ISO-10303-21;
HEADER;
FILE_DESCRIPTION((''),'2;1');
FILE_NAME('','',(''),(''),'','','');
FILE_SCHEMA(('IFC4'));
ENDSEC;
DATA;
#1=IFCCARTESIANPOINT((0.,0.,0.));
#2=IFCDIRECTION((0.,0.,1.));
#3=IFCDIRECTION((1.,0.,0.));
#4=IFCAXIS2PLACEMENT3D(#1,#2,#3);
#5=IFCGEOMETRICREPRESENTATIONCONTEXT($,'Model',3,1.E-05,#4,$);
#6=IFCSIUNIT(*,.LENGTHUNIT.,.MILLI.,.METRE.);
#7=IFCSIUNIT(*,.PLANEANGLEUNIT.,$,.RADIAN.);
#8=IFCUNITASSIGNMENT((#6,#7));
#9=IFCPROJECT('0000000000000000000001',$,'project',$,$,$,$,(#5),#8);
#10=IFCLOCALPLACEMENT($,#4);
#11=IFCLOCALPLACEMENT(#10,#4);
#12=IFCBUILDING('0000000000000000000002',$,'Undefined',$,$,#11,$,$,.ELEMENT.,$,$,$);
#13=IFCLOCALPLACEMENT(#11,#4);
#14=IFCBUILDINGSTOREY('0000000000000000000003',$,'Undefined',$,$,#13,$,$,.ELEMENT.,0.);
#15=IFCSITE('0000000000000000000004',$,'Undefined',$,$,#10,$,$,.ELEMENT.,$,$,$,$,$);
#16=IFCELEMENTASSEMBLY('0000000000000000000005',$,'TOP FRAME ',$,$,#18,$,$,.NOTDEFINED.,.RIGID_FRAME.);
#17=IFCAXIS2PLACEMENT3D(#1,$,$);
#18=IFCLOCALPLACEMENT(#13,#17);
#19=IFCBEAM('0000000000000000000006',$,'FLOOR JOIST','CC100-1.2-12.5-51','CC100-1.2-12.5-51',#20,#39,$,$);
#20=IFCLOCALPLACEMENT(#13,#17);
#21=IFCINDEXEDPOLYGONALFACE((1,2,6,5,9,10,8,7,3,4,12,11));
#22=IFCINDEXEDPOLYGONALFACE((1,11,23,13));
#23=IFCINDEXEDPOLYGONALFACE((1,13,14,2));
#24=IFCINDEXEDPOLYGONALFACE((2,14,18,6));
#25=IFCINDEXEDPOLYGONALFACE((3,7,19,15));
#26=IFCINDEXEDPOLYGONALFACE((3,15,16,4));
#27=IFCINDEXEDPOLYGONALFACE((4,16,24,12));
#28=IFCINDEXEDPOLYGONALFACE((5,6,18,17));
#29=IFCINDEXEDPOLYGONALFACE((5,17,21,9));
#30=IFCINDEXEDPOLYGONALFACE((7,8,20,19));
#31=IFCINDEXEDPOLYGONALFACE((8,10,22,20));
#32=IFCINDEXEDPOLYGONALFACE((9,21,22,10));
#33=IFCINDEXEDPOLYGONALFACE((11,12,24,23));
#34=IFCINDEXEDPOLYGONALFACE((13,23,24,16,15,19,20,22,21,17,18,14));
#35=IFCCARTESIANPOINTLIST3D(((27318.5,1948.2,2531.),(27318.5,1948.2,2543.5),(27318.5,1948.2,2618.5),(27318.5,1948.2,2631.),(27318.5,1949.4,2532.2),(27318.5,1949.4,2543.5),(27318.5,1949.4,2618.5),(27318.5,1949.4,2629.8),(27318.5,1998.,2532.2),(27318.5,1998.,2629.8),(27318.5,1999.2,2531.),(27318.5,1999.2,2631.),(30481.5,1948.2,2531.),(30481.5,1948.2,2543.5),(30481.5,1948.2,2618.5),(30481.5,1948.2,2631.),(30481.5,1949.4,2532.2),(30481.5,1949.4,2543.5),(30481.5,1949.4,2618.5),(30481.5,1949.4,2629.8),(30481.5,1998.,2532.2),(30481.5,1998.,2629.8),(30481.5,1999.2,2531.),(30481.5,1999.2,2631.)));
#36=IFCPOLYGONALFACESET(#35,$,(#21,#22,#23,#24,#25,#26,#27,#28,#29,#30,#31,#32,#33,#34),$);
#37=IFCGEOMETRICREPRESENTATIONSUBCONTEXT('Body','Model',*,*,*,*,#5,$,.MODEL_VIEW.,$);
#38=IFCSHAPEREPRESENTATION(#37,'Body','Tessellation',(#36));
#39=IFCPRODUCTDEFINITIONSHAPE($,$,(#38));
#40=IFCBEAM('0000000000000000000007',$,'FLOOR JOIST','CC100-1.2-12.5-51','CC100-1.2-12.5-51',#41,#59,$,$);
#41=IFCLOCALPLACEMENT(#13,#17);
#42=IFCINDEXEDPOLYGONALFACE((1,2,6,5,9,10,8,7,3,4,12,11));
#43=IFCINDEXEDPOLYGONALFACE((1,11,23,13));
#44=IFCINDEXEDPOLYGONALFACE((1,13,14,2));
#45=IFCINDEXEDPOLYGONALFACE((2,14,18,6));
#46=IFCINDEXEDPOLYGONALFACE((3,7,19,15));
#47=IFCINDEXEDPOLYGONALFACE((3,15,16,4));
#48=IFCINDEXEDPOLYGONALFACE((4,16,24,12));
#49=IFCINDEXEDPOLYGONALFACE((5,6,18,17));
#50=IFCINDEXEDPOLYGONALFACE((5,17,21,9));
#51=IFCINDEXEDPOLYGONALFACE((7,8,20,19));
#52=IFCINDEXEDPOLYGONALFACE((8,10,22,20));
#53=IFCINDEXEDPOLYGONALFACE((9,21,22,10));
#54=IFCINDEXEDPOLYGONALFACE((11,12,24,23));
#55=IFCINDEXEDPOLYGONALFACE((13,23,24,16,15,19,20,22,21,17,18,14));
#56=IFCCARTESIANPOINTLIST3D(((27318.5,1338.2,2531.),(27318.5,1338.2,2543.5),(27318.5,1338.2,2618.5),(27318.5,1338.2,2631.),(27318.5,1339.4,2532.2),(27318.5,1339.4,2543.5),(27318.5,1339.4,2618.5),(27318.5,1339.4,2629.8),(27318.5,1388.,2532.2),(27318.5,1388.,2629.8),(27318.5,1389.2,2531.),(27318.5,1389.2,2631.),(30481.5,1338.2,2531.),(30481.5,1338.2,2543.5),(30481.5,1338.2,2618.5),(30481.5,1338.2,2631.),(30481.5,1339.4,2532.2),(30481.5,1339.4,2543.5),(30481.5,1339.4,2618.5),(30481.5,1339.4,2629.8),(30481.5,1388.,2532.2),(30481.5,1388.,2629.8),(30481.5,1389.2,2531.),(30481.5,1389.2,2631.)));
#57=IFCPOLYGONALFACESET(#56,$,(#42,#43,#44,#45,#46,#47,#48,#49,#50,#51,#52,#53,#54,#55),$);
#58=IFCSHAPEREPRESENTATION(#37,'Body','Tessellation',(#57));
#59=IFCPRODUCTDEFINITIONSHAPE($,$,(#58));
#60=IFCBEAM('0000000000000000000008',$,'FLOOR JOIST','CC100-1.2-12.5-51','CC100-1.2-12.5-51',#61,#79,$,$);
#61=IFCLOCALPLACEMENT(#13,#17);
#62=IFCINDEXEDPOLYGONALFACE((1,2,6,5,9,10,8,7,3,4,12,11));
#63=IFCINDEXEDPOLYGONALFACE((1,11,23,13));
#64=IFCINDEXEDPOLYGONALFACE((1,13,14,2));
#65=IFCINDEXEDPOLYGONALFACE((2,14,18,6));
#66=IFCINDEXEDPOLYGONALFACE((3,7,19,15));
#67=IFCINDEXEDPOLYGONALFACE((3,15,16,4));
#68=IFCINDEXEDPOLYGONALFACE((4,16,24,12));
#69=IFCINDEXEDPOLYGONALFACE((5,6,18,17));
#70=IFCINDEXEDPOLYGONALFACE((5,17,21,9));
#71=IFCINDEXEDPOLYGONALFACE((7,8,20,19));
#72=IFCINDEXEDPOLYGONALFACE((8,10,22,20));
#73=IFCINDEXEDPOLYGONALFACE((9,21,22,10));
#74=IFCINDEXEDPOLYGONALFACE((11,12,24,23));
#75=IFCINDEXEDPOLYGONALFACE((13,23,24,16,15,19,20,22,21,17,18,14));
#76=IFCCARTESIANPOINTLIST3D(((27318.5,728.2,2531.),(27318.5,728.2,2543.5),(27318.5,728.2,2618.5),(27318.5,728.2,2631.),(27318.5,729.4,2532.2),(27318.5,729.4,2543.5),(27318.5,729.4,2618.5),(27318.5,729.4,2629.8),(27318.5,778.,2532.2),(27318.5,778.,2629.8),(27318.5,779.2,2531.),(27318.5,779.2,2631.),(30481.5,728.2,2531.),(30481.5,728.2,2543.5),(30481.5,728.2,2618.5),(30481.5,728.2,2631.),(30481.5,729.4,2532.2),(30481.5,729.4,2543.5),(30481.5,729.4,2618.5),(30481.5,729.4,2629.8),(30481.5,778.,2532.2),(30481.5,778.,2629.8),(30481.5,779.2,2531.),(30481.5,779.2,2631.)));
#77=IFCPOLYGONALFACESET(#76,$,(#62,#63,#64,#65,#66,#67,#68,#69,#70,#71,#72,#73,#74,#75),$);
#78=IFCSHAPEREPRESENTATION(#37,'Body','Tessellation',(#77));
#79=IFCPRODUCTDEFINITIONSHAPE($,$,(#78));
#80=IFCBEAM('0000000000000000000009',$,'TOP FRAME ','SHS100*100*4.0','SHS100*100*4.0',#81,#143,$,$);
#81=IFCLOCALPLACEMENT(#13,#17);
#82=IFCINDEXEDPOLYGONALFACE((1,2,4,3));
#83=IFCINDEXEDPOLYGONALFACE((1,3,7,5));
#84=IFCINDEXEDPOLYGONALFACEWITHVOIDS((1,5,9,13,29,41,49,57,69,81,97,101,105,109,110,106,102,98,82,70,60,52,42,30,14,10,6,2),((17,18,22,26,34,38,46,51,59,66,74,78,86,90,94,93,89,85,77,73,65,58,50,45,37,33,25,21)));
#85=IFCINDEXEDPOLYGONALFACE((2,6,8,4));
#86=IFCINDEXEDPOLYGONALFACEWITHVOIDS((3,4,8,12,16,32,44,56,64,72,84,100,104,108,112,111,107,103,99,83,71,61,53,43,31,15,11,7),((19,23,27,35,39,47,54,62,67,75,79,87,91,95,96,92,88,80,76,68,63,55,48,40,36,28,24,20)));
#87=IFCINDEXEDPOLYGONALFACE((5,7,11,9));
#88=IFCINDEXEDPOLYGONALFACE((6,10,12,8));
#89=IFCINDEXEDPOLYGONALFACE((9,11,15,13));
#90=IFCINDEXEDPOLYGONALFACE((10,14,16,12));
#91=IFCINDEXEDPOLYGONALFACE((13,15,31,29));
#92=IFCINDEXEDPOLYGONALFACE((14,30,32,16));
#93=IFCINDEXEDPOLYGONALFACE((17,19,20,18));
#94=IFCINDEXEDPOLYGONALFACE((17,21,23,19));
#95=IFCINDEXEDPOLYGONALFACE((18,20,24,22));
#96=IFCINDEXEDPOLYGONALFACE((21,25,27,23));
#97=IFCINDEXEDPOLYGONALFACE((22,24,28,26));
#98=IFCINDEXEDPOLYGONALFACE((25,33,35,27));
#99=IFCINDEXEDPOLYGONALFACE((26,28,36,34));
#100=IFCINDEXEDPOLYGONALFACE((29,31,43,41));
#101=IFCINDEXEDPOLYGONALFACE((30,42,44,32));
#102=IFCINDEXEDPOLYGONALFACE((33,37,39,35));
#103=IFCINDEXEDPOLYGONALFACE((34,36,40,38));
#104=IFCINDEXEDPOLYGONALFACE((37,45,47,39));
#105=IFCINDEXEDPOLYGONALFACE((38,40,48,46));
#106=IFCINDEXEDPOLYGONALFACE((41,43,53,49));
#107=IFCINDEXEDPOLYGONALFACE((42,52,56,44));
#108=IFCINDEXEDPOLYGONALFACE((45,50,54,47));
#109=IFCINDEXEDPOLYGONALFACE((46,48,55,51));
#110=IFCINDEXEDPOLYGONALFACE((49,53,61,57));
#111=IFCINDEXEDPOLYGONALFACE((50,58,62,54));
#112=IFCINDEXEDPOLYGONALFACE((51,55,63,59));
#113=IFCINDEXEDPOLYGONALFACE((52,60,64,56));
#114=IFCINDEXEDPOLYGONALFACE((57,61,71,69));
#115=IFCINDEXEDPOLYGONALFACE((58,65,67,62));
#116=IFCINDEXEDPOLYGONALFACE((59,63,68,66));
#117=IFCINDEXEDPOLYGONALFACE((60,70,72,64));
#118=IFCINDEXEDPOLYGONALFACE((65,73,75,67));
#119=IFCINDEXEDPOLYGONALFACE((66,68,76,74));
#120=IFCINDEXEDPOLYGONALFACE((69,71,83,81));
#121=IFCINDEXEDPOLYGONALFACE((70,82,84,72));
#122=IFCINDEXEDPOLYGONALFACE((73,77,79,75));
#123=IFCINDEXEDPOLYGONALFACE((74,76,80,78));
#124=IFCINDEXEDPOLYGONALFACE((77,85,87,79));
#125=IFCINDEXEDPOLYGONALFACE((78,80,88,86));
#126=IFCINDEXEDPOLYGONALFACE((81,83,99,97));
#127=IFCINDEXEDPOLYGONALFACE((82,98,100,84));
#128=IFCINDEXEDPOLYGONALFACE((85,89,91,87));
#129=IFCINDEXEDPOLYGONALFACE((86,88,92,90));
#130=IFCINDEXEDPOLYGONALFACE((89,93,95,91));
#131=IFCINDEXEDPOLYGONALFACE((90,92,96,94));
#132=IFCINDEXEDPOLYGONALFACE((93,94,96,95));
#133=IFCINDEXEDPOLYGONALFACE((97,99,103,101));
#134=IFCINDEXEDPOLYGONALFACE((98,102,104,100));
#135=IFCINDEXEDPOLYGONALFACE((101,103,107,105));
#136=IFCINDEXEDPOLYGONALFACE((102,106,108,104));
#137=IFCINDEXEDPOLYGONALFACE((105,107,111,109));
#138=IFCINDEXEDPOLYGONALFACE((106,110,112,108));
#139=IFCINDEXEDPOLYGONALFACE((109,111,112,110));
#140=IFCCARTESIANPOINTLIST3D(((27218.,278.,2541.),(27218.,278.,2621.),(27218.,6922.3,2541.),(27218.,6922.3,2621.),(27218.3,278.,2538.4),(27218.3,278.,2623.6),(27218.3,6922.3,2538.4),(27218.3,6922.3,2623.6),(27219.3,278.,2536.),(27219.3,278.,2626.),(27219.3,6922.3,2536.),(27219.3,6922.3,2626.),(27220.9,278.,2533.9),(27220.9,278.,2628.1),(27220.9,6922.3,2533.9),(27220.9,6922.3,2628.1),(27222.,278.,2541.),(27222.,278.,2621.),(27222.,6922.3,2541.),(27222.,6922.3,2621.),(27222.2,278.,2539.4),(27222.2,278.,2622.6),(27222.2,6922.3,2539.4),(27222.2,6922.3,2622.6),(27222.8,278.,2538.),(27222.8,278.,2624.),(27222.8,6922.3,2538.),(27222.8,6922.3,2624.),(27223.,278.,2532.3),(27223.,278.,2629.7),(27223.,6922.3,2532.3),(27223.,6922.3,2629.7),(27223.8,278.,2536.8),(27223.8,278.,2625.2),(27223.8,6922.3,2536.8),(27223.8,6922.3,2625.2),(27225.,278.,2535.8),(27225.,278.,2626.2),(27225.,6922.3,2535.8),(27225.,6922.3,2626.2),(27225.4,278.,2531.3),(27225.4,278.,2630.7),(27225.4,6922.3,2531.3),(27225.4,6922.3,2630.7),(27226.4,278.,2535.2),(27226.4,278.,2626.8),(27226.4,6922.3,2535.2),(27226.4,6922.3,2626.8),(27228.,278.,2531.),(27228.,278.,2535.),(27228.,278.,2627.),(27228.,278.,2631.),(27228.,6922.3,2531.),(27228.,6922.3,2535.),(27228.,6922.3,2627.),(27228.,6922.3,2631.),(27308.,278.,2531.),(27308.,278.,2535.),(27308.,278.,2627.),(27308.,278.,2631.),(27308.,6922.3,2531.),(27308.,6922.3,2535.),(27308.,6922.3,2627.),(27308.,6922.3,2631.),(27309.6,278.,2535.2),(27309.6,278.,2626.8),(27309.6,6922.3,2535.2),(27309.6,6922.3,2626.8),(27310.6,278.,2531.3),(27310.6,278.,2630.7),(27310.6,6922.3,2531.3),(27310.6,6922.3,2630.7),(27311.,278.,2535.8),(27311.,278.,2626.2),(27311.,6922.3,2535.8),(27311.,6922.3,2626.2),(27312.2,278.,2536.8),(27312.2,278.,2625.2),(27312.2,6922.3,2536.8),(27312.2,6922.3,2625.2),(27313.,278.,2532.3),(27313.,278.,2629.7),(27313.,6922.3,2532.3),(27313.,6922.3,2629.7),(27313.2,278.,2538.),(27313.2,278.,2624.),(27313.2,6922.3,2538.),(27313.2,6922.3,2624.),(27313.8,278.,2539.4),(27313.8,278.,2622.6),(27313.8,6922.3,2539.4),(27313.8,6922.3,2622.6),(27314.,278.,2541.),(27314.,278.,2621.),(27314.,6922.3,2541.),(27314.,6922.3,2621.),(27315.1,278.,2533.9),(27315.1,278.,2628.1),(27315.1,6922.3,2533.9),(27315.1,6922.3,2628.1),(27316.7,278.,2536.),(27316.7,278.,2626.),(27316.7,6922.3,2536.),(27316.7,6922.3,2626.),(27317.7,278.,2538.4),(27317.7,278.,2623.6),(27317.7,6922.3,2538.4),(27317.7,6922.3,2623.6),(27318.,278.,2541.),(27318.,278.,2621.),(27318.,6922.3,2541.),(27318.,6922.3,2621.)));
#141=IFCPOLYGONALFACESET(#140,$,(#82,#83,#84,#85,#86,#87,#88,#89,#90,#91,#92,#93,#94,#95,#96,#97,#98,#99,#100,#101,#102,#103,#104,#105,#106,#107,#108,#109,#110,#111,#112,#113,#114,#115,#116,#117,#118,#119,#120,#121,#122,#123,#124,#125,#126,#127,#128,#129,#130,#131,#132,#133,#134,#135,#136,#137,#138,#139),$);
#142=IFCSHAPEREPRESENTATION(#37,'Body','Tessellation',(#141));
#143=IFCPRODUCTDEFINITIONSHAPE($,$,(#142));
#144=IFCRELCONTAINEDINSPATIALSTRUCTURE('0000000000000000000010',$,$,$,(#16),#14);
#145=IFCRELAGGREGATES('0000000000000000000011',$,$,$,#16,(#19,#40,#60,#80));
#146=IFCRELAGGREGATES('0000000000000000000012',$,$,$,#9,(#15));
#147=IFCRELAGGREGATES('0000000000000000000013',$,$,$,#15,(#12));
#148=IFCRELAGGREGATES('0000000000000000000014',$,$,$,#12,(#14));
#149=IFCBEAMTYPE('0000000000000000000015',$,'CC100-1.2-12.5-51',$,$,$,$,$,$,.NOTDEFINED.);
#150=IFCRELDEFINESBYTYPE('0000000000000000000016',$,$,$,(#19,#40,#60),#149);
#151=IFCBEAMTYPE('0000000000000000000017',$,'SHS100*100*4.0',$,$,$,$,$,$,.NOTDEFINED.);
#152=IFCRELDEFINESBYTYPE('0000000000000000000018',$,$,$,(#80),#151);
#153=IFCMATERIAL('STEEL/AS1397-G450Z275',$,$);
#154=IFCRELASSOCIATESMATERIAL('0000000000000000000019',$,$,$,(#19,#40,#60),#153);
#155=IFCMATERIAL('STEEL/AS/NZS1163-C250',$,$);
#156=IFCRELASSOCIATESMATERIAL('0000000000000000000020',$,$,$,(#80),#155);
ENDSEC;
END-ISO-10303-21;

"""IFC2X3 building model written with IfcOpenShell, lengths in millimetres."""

from ifc_helpers import new_model, si_unit, frame, origin_with_axes, origin_2d_with_axis, place, context, subcontext, project, spatial, hollow_rectangle, c_section, extrude, material, type_object, element, aggregate, save


model = new_model("IFC2X3")

# Units and contexts
model_context = context("Model", 3, precision=1e-05, world=origin_with_axes())
body_context = subcontext(model_context, "Body", "Model", "MODEL_VIEW")
ifc_project = project(units=[si_unit("LENGTHUNIT", "METRE", prefix="MILLI"), si_unit("PLANEANGLEUNIT", "RADIAN")], contexts=[model_context])

# Site, building, storey
site_placement = place(None, origin_with_axes())
site = spatial("IfcSite", under=ifc_project, at=site_placement, Name="Undefined", CompositionType="ELEMENT")
building_placement = place(site_placement, origin_with_axes())
building = spatial("IfcBuilding", under=site, at=building_placement, Name="Undefined", CompositionType="ELEMENT")
storey_placement = place(building_placement, origin_with_axes())
storey = spatial("IfcBuildingStorey", under=building, at=storey_placement, Name="Undefined", CompositionType="ELEMENT", Elevation=0.0)

# Element assembly, beams
assembly_1_placement = place(storey_placement, origin_with_axes())
assembly_1 = element("IfcElementAssembly", 1, at=assembly_1_placement, inside=storey, Name="TOP FRAME ", AssemblyPlace="NOTDEFINED", PredefinedType="RIGID_FRAME")
ifc_material_1 = material(Name="STEEL/AS1397-G450Z275")
beam_type_1 = type_object("IfcBeamType", Name="CC100-1.2-12.5-51", PredefinedType="NOTDEFINED")
beam_1_placement = place(assembly_1_placement, frame((27318.5, 1973.7, 2581.0), z_axis=(0.0, 0.0, 1.0), x_axis=(1.0, 0.0, 0.0)))
beam_1 = element("IfcBeam", 2, at=beam_1_placement, type_object=beam_type_1, material=ifc_material_1, Name="FLOOR JOIST", Description="CC100-1.2-12.5-51", ObjectType="CC100-1.2-12.5-51", context=body_context, shape_type="SweptSolid", body=[
    extrude(c_section(Depth=100.0, Width=51.0, WallThickness=1.2, Girth=12.5, at=origin_2d_with_axis()), frame((3163.0, 0.0, 0.0), z_axis=(-1.0, 0.0, 0.0), x_axis=(0.0, -1.0, 0.0)), (0.0, 0.0, 1.0), 3163.0),
])
beam_2_placement = place(assembly_1_placement, frame((27318.5, 1363.7, 2581.0), z_axis=(0.0, 0.0, 1.0), x_axis=(1.0, 0.0, 0.0)))
beam_2 = element("IfcBeam", 3, at=beam_2_placement, type_object=beam_type_1, material=ifc_material_1, Name="FLOOR JOIST", Description="CC100-1.2-12.5-51", ObjectType="CC100-1.2-12.5-51", context=body_context, shape_type="SweptSolid", body=[
    extrude(c_section(Depth=100.0, Width=51.0, WallThickness=1.2, Girth=12.5, at=origin_2d_with_axis()), frame((3163.0, 0.0, 0.0), z_axis=(-1.0, 0.0, 0.0), x_axis=(0.0, -1.0, 0.0)), (0.0, 0.0, 1.0), 3163.0),
])
beam_3_placement = place(assembly_1_placement, frame((27318.5, 753.7, 2581.0), z_axis=(0.0, 0.0, 1.0), x_axis=(1.0, 0.0, 0.0)))
beam_3 = element("IfcBeam", 4, at=beam_3_placement, type_object=beam_type_1, material=ifc_material_1, Name="FLOOR JOIST", Description="CC100-1.2-12.5-51", ObjectType="CC100-1.2-12.5-51", context=body_context, shape_type="SweptSolid", body=[
    extrude(c_section(Depth=100.0, Width=51.0, WallThickness=1.2, Girth=12.5, at=origin_2d_with_axis()), frame((3163.0, 0.0, 0.0), z_axis=(-1.0, 0.0, 0.0), x_axis=(0.0, -1.0, 0.0)), (0.0, 0.0, 1.0), 3163.0),
])
ifc_material_2 = material(Name="STEEL/AS/NZS1163-C250")
beam_type_2 = type_object("IfcBeamType", Name="SHS100*100*4.0", PredefinedType="NOTDEFINED")
beam_4_placement = place(assembly_1_placement, frame((27268.0, 6922.3, 2581.0), z_axis=(0.0, 0.0, 1.0), x_axis=(0.0, -1.0, 0.0)))
beam_4 = element("IfcBeam", 5, at=beam_4_placement, type_object=beam_type_2, material=ifc_material_2, Name="TOP FRAME ", Description="SHS100*100*4.0", ObjectType="SHS100*100*4.0", context=body_context, shape_type="SweptSolid", body=[
    extrude(hollow_rectangle(XDim=100.0, YDim=100.0, WallThickness=4.0, InnerFilletRadius=6.0, OuterFilletRadius=10.0, at=origin_2d_with_axis()), frame((6644.3, 0.0, 0.0), z_axis=(-1.0, 0.0, 0.0), x_axis=(0.0, -1.0, 0.0)), (0.0, 0.0, 1.0), 6644.3),
])
aggregate(assembly_1, [beam_1, beam_2, beam_3, beam_4])

save(model, "model.ifc")
